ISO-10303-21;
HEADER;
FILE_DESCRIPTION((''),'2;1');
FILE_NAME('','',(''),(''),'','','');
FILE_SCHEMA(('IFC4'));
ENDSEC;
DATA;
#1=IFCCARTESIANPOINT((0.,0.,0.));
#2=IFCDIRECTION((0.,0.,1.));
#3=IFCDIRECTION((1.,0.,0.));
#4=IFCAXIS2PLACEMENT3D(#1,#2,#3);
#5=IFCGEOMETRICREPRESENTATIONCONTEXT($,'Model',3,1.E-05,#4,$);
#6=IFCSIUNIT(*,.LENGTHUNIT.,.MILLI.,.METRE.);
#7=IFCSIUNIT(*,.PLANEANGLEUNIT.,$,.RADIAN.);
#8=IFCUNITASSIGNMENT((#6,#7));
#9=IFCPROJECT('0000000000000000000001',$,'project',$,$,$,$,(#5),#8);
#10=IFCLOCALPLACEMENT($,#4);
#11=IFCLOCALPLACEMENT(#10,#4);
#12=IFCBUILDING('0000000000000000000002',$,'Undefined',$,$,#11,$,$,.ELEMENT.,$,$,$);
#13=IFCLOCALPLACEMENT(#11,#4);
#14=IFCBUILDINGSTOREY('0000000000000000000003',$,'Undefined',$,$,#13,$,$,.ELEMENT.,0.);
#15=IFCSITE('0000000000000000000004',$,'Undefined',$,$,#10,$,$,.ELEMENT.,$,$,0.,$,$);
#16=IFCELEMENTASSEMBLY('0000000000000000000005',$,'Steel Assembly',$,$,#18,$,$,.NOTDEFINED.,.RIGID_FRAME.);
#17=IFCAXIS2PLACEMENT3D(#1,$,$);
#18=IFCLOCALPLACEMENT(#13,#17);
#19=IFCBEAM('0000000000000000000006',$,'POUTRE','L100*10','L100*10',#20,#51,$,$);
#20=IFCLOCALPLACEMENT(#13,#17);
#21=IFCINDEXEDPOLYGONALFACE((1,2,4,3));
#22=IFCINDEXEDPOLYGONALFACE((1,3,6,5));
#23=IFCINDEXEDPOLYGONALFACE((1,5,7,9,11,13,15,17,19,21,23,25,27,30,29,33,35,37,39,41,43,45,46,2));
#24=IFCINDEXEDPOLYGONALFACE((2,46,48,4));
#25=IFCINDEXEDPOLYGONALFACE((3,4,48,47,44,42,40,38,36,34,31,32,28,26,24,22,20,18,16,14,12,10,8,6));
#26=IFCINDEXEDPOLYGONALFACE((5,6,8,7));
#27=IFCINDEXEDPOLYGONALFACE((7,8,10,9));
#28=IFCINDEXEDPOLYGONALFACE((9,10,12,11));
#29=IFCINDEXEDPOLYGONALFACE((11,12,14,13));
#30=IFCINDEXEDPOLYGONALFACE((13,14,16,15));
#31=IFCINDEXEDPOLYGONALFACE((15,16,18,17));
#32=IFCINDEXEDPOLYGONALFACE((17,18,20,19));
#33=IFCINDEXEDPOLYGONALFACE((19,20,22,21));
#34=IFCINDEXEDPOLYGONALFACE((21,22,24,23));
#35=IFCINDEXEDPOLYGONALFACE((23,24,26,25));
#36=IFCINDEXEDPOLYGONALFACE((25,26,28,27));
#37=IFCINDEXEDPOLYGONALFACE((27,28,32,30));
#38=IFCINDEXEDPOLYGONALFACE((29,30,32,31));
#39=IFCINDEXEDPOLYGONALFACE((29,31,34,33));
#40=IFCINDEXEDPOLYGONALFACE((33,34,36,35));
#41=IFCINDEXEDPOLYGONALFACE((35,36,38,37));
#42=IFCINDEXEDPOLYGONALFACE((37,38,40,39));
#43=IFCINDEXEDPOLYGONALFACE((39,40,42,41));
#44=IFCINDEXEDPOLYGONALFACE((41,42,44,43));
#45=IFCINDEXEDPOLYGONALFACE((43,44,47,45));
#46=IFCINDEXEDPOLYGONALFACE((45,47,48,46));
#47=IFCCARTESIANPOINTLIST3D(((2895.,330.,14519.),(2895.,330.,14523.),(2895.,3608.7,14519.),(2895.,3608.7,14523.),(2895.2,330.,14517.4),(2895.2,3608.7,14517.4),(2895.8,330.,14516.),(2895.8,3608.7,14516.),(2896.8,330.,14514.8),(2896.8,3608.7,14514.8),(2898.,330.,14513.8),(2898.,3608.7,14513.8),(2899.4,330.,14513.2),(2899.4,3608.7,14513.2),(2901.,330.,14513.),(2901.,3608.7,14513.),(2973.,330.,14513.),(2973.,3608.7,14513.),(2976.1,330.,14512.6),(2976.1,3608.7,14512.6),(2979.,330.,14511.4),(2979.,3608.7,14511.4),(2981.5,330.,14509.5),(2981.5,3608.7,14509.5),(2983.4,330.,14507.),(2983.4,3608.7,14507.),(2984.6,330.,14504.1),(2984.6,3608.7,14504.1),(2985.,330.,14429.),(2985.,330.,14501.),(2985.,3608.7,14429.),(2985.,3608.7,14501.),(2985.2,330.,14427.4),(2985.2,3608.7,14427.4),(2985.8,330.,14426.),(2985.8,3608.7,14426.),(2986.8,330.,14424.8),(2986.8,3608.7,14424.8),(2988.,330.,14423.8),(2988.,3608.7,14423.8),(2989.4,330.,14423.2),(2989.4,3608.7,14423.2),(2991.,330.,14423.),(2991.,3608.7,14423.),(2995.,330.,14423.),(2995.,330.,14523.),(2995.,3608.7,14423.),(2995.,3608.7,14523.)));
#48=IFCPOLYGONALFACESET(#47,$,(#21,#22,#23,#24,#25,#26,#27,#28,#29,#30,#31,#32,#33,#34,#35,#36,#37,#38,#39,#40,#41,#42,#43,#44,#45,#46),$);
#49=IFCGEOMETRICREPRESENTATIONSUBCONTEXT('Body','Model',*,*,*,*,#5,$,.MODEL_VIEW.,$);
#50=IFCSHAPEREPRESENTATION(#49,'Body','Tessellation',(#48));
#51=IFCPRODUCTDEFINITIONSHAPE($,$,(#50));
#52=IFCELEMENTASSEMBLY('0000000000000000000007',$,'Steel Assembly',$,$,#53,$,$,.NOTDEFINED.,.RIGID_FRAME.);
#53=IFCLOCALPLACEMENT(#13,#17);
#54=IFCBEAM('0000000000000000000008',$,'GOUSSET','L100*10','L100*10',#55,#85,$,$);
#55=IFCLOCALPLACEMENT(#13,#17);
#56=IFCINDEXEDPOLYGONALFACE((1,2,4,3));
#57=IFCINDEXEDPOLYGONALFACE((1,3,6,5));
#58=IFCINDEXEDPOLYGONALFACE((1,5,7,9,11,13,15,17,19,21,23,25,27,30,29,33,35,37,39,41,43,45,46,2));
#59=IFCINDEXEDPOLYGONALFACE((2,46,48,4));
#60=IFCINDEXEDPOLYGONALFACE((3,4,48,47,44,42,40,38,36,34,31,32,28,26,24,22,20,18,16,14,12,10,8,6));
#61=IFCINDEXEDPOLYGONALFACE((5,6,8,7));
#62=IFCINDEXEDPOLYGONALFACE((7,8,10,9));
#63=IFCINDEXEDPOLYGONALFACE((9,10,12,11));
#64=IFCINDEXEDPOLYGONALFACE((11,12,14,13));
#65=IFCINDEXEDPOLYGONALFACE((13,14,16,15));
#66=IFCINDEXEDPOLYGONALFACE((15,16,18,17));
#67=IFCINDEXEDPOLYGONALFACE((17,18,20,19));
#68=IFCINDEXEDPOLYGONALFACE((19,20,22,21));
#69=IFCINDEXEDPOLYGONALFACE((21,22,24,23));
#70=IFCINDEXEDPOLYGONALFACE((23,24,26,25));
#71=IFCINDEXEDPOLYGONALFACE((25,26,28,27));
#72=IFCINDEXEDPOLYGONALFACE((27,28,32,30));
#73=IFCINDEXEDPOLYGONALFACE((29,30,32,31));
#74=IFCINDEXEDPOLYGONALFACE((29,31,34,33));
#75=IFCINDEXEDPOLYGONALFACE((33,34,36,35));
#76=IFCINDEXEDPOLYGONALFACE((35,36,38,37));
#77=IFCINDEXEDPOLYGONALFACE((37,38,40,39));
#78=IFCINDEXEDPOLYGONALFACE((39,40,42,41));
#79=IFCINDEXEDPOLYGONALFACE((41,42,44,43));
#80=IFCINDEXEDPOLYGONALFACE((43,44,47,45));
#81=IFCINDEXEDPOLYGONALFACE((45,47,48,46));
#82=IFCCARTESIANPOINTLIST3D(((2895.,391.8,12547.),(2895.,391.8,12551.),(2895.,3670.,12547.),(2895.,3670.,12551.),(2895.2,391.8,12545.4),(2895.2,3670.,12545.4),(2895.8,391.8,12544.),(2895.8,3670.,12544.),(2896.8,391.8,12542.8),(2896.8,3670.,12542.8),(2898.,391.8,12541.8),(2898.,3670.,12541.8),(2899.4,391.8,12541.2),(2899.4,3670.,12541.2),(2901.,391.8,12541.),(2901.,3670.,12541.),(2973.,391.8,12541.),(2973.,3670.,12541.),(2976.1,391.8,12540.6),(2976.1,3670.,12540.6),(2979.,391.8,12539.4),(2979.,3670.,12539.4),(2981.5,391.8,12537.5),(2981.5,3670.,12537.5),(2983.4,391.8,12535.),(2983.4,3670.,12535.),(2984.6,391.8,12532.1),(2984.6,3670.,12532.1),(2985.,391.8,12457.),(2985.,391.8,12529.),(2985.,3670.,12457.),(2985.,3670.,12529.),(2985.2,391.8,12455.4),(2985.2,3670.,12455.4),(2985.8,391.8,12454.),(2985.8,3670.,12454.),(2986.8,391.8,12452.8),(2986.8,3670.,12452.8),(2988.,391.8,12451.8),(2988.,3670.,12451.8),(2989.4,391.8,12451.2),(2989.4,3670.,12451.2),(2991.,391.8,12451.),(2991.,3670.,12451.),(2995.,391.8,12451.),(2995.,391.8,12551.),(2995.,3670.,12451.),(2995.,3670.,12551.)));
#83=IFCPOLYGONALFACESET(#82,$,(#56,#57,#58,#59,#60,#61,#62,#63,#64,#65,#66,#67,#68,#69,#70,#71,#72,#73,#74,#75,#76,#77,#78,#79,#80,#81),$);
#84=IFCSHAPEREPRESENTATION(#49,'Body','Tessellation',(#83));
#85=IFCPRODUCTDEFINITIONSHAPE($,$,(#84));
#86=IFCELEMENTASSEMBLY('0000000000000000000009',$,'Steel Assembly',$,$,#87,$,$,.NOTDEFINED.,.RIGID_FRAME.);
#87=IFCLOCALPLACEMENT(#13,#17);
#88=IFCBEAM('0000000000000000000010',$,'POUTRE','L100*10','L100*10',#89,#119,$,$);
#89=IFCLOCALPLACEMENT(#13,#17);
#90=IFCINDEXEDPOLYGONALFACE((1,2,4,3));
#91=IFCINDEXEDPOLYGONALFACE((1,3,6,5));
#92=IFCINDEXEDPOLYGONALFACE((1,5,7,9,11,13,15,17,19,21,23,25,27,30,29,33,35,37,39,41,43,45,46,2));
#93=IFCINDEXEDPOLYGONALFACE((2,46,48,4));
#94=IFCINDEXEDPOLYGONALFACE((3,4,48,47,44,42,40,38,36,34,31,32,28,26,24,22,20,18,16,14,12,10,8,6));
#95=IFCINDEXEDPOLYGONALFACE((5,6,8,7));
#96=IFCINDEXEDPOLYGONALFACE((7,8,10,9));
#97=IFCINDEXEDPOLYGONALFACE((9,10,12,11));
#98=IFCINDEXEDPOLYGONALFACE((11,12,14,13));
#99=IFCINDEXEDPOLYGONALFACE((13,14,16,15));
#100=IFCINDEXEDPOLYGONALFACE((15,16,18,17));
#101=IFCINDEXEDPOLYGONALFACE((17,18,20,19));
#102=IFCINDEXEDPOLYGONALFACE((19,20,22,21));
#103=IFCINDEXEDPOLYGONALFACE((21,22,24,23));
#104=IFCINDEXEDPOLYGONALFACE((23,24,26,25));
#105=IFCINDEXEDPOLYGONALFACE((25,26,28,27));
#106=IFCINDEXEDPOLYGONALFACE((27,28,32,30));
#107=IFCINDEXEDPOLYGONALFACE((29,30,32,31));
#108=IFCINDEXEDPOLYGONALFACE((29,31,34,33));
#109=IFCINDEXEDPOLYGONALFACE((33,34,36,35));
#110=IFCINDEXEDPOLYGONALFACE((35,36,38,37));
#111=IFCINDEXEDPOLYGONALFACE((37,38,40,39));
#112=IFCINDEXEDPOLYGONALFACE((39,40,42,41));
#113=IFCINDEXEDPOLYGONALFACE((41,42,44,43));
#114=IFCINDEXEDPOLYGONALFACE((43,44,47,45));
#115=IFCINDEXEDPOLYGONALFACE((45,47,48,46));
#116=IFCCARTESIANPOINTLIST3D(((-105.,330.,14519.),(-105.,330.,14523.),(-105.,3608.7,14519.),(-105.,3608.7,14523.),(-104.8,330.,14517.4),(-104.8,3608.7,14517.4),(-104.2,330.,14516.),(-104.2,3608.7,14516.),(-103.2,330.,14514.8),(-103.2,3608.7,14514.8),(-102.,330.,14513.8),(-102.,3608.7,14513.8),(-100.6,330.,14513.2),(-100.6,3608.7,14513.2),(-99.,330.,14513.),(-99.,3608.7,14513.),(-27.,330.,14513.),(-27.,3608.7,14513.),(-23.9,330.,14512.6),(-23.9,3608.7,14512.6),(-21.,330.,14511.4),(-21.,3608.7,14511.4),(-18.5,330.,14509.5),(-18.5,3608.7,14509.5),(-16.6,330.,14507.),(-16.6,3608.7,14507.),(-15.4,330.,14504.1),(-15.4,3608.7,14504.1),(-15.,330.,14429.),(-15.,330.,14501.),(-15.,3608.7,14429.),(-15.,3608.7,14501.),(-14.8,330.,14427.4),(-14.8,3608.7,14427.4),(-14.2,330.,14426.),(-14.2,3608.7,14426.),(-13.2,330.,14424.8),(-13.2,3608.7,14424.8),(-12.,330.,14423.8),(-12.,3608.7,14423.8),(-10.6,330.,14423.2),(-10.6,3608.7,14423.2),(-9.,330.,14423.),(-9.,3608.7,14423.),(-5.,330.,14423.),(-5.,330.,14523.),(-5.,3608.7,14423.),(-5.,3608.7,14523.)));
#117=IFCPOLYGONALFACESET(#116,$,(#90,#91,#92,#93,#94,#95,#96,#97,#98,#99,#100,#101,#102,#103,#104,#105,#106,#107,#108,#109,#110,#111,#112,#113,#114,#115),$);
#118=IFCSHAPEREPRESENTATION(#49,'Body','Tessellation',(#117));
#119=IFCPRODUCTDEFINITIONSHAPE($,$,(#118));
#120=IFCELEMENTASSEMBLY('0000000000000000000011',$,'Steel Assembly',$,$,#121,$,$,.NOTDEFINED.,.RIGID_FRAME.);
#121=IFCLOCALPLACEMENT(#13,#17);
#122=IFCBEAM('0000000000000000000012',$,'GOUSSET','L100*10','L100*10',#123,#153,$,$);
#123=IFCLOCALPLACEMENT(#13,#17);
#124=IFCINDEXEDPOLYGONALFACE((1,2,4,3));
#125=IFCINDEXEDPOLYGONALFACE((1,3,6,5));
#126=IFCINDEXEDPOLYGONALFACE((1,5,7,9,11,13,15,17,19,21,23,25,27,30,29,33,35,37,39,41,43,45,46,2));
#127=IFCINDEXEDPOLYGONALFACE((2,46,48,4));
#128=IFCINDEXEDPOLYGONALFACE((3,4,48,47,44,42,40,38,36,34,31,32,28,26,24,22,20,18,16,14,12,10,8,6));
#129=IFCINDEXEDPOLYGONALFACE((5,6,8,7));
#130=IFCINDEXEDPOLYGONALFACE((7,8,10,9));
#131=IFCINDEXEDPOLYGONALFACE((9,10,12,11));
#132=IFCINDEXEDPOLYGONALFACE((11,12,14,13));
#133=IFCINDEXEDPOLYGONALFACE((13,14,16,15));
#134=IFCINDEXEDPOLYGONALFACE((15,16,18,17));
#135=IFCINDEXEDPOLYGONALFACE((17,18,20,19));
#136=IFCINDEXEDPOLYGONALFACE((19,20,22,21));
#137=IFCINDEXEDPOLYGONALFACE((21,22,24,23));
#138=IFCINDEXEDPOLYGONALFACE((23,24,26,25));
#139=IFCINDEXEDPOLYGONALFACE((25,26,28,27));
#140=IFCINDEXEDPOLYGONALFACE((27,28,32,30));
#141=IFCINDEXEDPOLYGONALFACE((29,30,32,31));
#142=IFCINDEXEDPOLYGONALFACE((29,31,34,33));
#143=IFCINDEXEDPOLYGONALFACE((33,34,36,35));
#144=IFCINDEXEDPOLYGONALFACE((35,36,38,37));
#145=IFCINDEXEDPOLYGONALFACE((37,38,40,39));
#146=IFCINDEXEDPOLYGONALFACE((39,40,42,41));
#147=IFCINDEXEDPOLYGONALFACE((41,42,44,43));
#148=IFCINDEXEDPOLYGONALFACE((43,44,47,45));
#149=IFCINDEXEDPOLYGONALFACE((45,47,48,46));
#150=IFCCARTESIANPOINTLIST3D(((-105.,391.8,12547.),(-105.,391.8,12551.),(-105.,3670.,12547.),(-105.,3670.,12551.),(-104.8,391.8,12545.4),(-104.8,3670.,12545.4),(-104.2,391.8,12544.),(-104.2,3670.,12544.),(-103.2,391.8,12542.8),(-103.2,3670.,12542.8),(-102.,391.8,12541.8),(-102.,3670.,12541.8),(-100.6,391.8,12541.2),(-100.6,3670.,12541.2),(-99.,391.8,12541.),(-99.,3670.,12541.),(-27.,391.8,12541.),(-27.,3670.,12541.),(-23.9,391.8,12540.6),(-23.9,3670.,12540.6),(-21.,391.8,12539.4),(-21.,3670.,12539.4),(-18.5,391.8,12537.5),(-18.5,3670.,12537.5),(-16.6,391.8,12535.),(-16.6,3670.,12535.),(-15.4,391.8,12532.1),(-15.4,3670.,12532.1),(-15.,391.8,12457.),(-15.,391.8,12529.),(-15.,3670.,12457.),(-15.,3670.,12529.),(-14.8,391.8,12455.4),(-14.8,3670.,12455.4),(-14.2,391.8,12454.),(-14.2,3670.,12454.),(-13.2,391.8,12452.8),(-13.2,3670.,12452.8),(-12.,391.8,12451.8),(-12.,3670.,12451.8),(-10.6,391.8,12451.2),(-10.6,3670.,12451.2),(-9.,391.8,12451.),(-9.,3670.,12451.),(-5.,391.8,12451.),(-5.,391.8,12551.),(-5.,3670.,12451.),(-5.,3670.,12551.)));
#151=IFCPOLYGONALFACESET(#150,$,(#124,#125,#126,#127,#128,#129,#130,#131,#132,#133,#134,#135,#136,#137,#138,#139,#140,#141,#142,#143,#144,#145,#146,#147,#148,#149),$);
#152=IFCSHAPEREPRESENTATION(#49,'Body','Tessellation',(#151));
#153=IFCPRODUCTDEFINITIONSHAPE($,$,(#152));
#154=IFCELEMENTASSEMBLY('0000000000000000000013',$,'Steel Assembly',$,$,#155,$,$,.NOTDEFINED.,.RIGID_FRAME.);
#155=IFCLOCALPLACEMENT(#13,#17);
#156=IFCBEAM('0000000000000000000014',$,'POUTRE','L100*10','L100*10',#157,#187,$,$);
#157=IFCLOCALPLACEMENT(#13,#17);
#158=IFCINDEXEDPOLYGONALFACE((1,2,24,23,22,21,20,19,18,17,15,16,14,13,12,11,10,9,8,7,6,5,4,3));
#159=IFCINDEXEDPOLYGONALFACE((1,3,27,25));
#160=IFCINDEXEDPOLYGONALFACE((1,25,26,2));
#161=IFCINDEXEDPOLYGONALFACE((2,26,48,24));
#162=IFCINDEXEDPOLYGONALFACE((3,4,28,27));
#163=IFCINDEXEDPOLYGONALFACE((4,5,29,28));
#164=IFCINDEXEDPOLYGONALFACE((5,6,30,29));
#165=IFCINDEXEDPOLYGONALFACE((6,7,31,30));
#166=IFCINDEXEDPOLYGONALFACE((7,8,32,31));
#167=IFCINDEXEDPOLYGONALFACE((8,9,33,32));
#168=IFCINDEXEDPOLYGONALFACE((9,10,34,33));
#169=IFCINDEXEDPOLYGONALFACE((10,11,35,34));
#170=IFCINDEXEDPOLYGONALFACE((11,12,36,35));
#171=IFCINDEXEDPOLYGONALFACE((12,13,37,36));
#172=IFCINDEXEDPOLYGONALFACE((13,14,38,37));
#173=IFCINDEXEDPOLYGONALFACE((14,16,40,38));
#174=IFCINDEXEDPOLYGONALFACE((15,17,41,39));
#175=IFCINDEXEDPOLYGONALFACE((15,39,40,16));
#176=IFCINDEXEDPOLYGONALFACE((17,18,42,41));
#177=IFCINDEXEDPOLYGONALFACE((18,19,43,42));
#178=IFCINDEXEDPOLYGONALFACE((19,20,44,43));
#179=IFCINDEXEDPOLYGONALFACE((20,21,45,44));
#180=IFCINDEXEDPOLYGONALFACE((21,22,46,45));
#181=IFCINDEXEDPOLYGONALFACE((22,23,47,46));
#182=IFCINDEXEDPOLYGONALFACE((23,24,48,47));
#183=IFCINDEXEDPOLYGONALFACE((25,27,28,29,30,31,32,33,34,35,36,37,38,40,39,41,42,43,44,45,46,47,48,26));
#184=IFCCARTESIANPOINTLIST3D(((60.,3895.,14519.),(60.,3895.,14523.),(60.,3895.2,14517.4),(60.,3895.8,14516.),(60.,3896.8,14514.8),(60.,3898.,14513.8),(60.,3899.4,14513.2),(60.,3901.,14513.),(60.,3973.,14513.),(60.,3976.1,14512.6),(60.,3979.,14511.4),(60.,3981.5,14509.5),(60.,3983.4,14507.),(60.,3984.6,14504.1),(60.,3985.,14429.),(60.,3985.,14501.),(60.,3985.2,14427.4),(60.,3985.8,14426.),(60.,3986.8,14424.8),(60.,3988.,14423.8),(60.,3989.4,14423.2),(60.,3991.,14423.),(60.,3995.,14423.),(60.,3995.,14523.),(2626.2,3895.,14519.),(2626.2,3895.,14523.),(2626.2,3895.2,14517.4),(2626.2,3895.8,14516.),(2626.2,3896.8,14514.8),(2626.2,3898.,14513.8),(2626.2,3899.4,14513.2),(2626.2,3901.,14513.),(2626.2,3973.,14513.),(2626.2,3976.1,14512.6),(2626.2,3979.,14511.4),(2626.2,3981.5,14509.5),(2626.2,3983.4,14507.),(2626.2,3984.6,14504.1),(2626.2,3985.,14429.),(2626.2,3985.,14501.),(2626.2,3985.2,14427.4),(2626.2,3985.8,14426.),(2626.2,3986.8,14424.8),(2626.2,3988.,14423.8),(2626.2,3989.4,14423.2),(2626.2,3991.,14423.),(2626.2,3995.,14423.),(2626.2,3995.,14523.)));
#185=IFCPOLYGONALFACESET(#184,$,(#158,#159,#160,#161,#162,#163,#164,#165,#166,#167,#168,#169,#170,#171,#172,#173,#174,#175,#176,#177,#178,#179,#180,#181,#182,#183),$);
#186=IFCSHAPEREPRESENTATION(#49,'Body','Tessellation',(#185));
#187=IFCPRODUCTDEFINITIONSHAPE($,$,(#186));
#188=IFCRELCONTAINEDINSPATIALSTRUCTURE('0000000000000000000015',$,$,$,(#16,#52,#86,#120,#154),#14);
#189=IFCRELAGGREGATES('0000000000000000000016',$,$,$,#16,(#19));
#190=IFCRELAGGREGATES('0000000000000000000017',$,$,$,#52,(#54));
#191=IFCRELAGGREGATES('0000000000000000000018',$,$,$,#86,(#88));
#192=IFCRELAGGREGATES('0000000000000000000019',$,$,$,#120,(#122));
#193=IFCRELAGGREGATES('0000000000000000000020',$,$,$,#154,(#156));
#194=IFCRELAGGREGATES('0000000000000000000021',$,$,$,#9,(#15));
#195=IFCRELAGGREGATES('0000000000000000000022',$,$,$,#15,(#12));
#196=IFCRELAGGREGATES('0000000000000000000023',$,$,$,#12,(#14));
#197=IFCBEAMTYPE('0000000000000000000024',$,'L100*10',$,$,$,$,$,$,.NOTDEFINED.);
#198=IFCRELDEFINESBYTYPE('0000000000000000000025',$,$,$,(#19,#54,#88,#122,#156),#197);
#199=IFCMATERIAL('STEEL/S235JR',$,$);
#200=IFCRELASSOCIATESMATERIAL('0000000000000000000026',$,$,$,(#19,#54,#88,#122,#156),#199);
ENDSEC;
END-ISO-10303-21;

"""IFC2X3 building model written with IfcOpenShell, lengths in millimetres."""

from ifc_helpers import new_model, si_unit, frame, origin_with_axes, origin_2d_with_axis, place, context, subcontext, project, spatial, l_section, extrude, material, type_object, element, aggregate, save


model = new_model("IFC2X3")

# Units and contexts
model_context = context("Model", 3, precision=1e-05, world=origin_with_axes())
body_context = subcontext(model_context, "Body", "Model", "MODEL_VIEW")
ifc_project = project(units=[si_unit("LENGTHUNIT", "METRE", prefix="MILLI"), si_unit("PLANEANGLEUNIT", "RADIAN")], contexts=[model_context])

# Site, building, storey
site_placement = place(None, origin_with_axes())
site = spatial("IfcSite", under=ifc_project, at=site_placement, Name="Undefined", CompositionType="ELEMENT", RefElevation=0.0)
building_placement = place(site_placement, origin_with_axes())
building = spatial("IfcBuilding", under=site, at=building_placement, Name="Undefined", CompositionType="ELEMENT")
storey_placement = place(building_placement, origin_with_axes())
storey = spatial("IfcBuildingStorey", under=building, at=storey_placement, Name="Undefined", CompositionType="ELEMENT", Elevation=0.0)

# Element assemblies, beams
assembly_1_placement = place(storey_placement, origin_with_axes())
assembly_1 = element("IfcElementAssembly", 1, at=assembly_1_placement, inside=storey, Name="Steel Assembly", AssemblyPlace="NOTDEFINED", PredefinedType="RIGID_FRAME")
ifc_material_1 = material(Name="STEEL/S235JR")
beam_type = type_object("IfcBeamType", Name="L100*10", PredefinedType="NOTDEFINED")
beam_1_placement = place(assembly_1_placement, frame((2945.0, 3608.7, 14473.0), z_axis=(-1.0, 0.0, 0.0), x_axis=(0.0, -1.0, 0.0)))
beam_1 = element("IfcBeam", 2, at=beam_1_placement, type_object=beam_type, material=ifc_material_1, Name="POUTRE", Description="L100*10", ObjectType="L100*10", context=body_context, shape_type="SweptSolid", body=[
    extrude(l_section(Depth=100.0, Width=100.0, Thickness=10.0, FilletRadius=12.0, EdgeRadius=6.0, at=origin_2d_with_axis()), frame((3278.7, 0.0, 0.0), z_axis=(-1.0, 0.0, 0.0), x_axis=(0.0, -1.0, 0.0)), (0.0, 0.0, 1.0), 3278.7),
])
assembly_2_placement = place(storey_placement, origin_with_axes())
assembly_2 = element("IfcElementAssembly", 3, at=assembly_2_placement, inside=storey, Name="Steel Assembly", AssemblyPlace="NOTDEFINED", PredefinedType="RIGID_FRAME")
beam_2_placement = place(assembly_2_placement, frame((2945.0, 3670.0, 12501.0), z_axis=(-1.0, 0.0, 0.0), x_axis=(0.0, -1.0, 0.0)))
beam_2 = element("IfcBeam", 4, at=beam_2_placement, type_object=beam_type, material=ifc_material_1, Name="GOUSSET", Description="L100*10", ObjectType="L100*10", context=body_context, shape_type="SweptSolid", body=[
    extrude(l_section(Depth=100.0, Width=100.0, Thickness=10.0, FilletRadius=12.0, EdgeRadius=6.0, at=origin_2d_with_axis()), frame((3278.2, 0.0, 0.0), z_axis=(-1.0, 0.0, 0.0), x_axis=(0.0, -1.0, 0.0)), (0.0, 0.0, 1.0), 3278.2),
])
assembly_3_placement = place(storey_placement, origin_with_axes())
assembly_3 = element("IfcElementAssembly", 5, at=assembly_3_placement, inside=storey, Name="Steel Assembly", AssemblyPlace="NOTDEFINED", PredefinedType="RIGID_FRAME")
beam_3_placement = place(assembly_3_placement, frame((-55.0, 3608.7, 14473.0), z_axis=(-1.0, 0.0, 0.0), x_axis=(0.0, -1.0, 0.0)))
beam_3 = element("IfcBeam", 6, at=beam_3_placement, type_object=beam_type, material=ifc_material_1, Name="POUTRE", Description="L100*10", ObjectType="L100*10", context=body_context, shape_type="SweptSolid", body=[
    extrude(l_section(Depth=100.0, Width=100.0, Thickness=10.0, FilletRadius=12.0, EdgeRadius=6.0, at=origin_2d_with_axis()), frame((3278.7, 0.0, 0.0), z_axis=(-1.0, 0.0, 0.0), x_axis=(0.0, -1.0, 0.0)), (0.0, 0.0, 1.0), 3278.7),
])
assembly_4_placement = place(storey_placement, origin_with_axes())
assembly_4 = element("IfcElementAssembly", 7, at=assembly_4_placement, inside=storey, Name="Steel Assembly", AssemblyPlace="NOTDEFINED", PredefinedType="RIGID_FRAME")
beam_4_placement = place(assembly_4_placement, frame((-55.0, 3670.0, 12501.0), z_axis=(-1.0, 0.0, 0.0), x_axis=(0.0, -1.0, 0.0)))
beam_4 = element("IfcBeam", 8, at=beam_4_placement, type_object=beam_type, material=ifc_material_1, Name="GOUSSET", Description="L100*10", ObjectType="L100*10", context=body_context, shape_type="SweptSolid", body=[
    extrude(l_section(Depth=100.0, Width=100.0, Thickness=10.0, FilletRadius=12.0, EdgeRadius=6.0, at=origin_2d_with_axis()), frame((3278.2, 0.0, 0.0), z_axis=(-1.0, 0.0, 0.0), x_axis=(0.0, -1.0, 0.0)), (0.0, 0.0, 1.0), 3278.2),
])
assembly_5_placement = place(storey_placement, origin_with_axes())
assembly_5 = element("IfcElementAssembly", 9, at=assembly_5_placement, inside=storey, Name="Steel Assembly", AssemblyPlace="NOTDEFINED", PredefinedType="RIGID_FRAME")
beam_5_placement = place(assembly_5_placement, frame((60.0, 3945.0, 14473.0), z_axis=(0.0, -1.0, 0.0), x_axis=(1.0, 0.0, 0.0)))
beam_5 = element("IfcBeam", 10, at=beam_5_placement, type_object=beam_type, material=ifc_material_1, Name="POUTRE", Description="L100*10", ObjectType="L100*10", context=body_context, shape_type="SweptSolid", body=[
    extrude(l_section(Depth=100.0, Width=100.0, Thickness=10.0, FilletRadius=12.0, EdgeRadius=6.0, at=origin_2d_with_axis()), frame((2566.2, 0.0, 0.0), z_axis=(-1.0, 0.0, 0.0), x_axis=(0.0, -1.0, 0.0)), (0.0, 0.0, 1.0), 2566.2),
])

aggregate(assembly_1, [beam_1])

aggregate(assembly_2, [beam_2])
aggregate(assembly_3, [beam_3])

aggregate(assembly_4, [beam_4])
aggregate(assembly_5, [beam_5])

save(model, "model.ifc")
